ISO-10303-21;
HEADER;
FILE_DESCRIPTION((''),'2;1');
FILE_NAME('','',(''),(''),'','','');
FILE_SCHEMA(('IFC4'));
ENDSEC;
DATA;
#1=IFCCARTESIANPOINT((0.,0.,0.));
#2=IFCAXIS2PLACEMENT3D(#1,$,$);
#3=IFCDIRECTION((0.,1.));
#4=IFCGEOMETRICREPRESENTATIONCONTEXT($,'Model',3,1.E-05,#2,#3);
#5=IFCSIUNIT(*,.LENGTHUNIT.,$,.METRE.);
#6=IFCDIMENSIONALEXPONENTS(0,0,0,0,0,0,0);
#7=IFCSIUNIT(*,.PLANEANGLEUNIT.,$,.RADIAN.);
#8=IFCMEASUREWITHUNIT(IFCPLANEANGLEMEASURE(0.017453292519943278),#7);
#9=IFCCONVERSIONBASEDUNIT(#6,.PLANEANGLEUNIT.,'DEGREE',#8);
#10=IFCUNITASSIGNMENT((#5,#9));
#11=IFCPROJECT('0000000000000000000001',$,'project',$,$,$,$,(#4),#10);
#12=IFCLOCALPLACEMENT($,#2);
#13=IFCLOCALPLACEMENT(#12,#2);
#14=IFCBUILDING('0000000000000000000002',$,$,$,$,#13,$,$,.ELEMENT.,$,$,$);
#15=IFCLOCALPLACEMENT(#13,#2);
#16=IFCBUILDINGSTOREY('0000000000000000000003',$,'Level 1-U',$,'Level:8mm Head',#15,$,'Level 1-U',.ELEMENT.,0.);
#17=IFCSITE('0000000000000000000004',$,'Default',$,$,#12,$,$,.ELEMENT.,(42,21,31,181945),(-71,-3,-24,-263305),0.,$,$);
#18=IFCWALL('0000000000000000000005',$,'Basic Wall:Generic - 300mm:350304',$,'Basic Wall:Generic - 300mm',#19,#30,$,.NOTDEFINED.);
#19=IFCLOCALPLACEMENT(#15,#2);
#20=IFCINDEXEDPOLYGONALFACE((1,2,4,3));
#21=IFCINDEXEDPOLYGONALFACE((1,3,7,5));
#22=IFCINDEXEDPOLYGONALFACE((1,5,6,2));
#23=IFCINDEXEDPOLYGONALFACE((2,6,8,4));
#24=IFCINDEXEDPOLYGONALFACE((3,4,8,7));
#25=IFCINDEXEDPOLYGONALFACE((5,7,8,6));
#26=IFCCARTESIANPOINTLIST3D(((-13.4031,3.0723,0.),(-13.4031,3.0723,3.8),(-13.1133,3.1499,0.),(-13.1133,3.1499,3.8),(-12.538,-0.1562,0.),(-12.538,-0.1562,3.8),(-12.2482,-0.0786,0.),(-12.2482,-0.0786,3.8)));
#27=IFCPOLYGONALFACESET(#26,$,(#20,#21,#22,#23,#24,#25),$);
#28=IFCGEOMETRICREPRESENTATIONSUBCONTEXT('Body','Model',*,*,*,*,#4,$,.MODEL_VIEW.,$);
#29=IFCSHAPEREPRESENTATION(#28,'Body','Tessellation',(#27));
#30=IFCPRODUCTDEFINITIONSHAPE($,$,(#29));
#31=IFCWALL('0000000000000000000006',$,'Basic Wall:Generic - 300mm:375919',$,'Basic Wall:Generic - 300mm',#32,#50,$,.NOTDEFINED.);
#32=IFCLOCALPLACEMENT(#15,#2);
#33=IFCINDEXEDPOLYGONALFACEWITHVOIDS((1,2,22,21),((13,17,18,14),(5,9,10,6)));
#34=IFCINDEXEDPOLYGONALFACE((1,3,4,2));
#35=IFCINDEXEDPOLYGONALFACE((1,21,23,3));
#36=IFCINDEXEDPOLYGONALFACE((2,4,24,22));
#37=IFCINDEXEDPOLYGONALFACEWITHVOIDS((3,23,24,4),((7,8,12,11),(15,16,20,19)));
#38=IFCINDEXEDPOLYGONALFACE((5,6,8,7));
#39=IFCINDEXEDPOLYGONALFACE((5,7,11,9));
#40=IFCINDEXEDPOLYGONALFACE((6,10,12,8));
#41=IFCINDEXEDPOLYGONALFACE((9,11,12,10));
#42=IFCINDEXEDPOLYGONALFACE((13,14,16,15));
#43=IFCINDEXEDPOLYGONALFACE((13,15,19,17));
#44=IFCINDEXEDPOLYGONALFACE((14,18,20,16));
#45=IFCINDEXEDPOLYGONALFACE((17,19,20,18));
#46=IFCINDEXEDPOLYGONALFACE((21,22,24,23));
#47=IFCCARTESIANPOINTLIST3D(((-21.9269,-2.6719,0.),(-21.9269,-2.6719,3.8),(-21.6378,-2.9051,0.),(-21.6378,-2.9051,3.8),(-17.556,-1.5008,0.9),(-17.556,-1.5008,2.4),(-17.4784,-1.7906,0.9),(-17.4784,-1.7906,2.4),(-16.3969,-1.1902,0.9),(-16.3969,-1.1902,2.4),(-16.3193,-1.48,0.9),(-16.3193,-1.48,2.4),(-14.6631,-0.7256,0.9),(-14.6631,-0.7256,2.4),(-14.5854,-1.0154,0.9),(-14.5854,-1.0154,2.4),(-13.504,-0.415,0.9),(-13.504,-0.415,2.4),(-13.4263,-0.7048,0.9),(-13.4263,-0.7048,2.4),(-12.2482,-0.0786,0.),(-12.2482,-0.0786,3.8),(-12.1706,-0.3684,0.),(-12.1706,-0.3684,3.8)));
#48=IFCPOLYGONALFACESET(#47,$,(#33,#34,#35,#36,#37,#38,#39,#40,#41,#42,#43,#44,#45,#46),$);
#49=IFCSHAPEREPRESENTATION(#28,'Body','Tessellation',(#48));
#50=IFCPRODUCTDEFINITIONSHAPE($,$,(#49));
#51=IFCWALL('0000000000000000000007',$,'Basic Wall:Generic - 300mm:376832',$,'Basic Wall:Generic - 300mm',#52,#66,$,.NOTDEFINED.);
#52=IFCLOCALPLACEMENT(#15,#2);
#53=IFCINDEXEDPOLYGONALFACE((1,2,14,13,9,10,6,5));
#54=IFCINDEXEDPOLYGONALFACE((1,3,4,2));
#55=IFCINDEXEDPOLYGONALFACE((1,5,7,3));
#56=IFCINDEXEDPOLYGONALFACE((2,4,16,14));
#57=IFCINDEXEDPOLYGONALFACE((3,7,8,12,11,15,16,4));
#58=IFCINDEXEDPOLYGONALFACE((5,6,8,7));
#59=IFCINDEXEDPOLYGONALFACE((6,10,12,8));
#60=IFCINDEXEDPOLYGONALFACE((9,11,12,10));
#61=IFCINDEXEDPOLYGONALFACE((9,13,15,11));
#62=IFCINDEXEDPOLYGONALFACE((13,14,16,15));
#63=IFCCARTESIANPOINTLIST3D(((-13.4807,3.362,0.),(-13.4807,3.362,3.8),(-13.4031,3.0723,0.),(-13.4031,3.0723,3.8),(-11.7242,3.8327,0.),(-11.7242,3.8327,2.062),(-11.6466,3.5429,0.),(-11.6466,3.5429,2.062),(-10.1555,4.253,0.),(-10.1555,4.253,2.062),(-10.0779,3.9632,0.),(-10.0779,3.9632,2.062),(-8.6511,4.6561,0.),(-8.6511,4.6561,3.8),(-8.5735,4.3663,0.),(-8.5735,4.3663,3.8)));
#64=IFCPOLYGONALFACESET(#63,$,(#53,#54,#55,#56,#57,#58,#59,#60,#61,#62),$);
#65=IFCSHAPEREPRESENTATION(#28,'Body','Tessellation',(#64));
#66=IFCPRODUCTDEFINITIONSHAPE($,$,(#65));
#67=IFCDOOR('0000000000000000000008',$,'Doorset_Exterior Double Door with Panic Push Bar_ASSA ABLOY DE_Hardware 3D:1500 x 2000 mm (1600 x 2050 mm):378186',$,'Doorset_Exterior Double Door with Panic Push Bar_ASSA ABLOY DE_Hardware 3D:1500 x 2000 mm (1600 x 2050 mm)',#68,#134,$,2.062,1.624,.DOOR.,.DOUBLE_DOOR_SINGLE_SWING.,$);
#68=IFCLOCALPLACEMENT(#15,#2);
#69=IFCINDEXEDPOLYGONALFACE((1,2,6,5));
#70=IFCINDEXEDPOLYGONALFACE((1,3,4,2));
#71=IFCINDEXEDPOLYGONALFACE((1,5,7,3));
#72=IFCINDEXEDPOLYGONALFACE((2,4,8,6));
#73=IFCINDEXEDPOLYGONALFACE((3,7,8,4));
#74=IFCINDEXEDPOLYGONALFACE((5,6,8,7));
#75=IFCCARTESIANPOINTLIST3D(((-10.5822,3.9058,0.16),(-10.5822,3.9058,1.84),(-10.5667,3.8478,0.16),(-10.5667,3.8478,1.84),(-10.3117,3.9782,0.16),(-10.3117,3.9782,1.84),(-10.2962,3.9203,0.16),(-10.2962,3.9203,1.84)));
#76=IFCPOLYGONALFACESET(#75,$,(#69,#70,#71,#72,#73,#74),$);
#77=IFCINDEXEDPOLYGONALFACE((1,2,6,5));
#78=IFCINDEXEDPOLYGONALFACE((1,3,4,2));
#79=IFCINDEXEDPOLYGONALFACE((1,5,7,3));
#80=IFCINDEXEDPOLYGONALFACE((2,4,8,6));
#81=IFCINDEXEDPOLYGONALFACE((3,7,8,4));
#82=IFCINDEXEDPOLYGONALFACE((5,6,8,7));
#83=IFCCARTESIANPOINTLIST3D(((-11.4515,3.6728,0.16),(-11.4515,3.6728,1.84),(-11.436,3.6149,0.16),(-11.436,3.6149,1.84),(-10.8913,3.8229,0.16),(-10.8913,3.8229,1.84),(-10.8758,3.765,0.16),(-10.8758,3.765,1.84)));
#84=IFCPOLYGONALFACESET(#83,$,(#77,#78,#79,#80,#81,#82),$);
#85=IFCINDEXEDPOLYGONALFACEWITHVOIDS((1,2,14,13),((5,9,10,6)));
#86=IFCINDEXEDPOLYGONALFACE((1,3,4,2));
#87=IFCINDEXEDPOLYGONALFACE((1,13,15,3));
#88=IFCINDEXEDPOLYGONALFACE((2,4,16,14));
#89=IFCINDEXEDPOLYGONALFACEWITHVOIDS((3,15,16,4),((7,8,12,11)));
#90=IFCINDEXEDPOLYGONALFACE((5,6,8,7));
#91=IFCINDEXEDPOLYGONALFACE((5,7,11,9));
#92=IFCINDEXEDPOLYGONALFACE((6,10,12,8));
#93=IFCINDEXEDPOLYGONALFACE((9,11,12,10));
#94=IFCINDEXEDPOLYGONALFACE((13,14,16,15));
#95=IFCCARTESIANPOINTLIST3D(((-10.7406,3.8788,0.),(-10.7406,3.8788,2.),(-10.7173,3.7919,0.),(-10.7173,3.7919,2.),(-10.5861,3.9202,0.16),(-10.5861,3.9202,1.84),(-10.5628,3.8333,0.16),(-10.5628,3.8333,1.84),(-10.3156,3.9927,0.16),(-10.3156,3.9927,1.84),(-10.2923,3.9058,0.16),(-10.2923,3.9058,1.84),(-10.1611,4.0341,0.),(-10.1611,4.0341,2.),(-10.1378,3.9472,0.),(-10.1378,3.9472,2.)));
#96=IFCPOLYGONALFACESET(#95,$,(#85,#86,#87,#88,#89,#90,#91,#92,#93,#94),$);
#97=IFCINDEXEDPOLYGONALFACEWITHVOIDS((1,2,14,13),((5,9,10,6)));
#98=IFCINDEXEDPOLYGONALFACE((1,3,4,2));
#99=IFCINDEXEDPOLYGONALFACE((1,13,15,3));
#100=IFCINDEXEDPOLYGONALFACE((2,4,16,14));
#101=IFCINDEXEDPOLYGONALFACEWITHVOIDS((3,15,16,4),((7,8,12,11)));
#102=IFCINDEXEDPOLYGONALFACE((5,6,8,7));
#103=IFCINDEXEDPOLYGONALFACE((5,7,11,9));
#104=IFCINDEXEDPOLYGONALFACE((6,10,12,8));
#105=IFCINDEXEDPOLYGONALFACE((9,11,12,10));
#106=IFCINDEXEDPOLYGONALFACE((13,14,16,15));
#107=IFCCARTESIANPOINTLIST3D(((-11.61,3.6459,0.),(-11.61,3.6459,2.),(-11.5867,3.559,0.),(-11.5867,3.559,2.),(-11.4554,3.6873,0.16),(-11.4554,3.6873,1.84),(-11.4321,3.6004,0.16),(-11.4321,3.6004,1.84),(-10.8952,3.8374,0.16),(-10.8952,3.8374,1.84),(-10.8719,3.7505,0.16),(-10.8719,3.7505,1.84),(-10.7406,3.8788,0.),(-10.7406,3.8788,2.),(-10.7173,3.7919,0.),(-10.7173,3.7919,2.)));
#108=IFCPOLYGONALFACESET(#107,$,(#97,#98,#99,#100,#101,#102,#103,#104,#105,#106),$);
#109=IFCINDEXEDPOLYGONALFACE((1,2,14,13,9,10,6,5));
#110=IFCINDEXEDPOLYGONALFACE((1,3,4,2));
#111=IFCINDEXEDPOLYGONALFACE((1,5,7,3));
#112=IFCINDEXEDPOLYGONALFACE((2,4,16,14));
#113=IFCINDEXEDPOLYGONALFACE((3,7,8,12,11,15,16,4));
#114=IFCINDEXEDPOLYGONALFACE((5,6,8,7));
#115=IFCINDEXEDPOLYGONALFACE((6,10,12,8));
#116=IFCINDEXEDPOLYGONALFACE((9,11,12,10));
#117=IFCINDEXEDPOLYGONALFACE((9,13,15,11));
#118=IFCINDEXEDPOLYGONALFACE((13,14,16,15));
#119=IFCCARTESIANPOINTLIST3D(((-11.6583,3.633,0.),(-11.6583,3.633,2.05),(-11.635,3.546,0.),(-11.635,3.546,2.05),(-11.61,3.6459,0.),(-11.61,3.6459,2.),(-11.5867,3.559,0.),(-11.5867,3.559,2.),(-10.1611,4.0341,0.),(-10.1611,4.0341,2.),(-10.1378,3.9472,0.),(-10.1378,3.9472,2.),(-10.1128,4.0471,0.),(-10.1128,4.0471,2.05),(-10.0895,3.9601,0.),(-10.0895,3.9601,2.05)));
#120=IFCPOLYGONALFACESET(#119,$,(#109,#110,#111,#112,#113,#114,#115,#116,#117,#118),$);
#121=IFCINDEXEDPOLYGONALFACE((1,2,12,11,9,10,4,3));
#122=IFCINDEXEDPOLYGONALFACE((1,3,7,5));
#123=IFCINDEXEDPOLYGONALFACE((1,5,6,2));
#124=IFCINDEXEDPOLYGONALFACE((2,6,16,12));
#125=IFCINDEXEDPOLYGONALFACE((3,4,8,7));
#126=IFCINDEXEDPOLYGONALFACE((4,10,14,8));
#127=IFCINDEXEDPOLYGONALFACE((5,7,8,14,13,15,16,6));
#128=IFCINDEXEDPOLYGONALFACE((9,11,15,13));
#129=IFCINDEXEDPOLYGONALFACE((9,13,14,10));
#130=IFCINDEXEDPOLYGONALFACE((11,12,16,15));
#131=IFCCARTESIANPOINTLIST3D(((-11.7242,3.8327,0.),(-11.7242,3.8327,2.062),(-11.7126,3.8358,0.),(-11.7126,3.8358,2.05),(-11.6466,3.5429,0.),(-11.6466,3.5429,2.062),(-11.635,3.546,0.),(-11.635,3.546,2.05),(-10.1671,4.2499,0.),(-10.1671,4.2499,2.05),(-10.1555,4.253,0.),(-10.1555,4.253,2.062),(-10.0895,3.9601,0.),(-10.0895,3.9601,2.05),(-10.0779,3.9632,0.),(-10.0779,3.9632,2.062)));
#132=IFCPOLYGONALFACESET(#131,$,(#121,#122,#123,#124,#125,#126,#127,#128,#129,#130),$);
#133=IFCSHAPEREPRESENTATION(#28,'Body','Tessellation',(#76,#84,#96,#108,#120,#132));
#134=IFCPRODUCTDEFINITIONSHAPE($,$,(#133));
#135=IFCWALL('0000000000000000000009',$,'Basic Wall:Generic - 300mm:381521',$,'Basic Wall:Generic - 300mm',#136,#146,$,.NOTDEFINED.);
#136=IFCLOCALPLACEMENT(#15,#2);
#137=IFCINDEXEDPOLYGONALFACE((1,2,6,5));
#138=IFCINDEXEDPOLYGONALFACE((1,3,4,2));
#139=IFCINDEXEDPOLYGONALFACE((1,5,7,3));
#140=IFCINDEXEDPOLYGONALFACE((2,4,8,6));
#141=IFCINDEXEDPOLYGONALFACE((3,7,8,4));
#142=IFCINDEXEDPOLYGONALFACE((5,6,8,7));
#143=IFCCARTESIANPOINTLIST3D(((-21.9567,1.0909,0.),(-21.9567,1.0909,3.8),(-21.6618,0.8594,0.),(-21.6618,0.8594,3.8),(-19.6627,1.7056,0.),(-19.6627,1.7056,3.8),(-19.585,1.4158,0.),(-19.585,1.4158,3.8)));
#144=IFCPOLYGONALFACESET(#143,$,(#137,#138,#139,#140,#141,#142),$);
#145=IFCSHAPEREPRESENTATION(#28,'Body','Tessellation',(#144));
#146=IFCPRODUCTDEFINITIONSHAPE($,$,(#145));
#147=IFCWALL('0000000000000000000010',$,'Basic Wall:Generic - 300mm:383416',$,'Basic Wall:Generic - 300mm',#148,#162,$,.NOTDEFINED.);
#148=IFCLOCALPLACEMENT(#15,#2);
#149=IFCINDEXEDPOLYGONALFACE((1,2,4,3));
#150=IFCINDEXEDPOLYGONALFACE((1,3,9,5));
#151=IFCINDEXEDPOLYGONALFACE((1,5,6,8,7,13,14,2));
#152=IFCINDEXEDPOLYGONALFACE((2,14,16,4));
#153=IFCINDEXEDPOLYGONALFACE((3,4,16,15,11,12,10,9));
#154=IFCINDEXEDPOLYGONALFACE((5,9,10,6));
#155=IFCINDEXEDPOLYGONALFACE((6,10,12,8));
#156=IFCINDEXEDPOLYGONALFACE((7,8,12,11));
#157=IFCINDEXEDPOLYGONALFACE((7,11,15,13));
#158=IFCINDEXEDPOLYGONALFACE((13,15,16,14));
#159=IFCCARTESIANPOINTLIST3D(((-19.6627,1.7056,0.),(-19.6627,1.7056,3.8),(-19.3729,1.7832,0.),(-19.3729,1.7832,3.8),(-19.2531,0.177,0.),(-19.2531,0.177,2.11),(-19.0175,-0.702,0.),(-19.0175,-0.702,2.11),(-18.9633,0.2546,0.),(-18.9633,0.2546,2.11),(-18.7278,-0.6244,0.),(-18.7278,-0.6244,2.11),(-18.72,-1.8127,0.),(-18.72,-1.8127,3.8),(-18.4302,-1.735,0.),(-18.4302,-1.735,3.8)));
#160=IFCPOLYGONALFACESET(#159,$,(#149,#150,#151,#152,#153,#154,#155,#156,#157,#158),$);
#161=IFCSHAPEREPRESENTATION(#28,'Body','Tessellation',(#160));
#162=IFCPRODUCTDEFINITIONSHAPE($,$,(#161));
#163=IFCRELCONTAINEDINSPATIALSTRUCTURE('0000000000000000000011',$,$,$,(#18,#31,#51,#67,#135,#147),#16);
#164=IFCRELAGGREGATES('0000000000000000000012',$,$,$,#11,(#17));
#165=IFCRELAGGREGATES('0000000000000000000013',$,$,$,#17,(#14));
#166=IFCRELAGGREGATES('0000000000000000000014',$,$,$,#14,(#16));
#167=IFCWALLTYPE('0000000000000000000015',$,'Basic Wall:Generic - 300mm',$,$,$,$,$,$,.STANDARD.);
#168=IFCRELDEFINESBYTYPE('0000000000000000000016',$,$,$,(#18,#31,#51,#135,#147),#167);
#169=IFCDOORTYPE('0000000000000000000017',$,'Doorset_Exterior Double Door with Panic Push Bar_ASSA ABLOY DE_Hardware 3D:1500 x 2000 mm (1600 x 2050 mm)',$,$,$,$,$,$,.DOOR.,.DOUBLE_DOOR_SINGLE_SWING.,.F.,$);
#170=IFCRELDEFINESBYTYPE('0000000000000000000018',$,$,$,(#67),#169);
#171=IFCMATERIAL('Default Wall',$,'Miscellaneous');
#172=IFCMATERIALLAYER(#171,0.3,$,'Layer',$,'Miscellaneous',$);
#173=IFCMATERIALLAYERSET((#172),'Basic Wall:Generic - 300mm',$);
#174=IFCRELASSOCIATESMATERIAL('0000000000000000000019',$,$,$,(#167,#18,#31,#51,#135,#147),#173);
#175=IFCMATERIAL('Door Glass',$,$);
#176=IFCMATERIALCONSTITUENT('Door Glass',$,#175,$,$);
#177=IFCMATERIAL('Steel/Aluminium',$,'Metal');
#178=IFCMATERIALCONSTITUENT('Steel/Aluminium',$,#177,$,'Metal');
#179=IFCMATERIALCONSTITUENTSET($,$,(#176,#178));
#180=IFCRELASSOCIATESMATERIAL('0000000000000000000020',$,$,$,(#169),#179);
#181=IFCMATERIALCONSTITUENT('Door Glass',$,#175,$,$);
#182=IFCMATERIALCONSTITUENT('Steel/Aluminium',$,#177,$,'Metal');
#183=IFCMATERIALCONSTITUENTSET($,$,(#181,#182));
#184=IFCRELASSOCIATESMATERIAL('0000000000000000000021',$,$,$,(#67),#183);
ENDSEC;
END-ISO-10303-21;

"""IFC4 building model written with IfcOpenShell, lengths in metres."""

from ifc_helpers import new_model, entity, si_unit, converted_unit, direction, frame, frame_2d, origin, place, context, subcontext, project, spatial, polyline, rectangle, outline, extrude, source, transform, mapped, material, layer, layer_set, layer_usage, constituent, constituent_set, type_object, type_shapes, element, fill, save


model = new_model("IFC4")

# Units and contexts
model_context = context("Model", 3, precision=1e-05, world=origin(), true_north=direction((0.0, 1.0)))
body_context = subcontext(model_context, "Body", "Model", "MODEL_VIEW")
ifc_project = project(units=[si_unit("LENGTHUNIT", "METRE"), converted_unit("PLANEANGLEUNIT", "DEGREE", entity("IfcPlaneAngleMeasure", 0.017453292519943278), si_unit("PLANEANGLEUNIT", "RADIAN"), dimensions=[0, 0, 0, 0, 0, 0, 0])], contexts=[model_context])

# Site, building, storey
site_placement = place(None, origin())
site = spatial("IfcSite", under=ifc_project, at=site_placement, Name="Default", CompositionType="ELEMENT", RefLatitude=(42, 21, 31, 181945), RefLongitude=(-71, -3, -24, -263305), RefElevation=0.0)
building_placement = place(site_placement, origin())
building = spatial("IfcBuilding", under=site, at=building_placement, CompositionType="ELEMENT")
storey_placement = place(building_placement, origin())
storey = spatial("IfcBuildingStorey", under=building, at=storey_placement, Name="Level 1-U", ObjectType="Level:8mm Head", LongName="Level 1-U", CompositionType="ELEMENT", Elevation=0.0)

# Wall
ifc_material_1 = material(Name="Default Wall", Category="Miscellaneous")
ifc_layer_1 = layer(ifc_material_1, 0.3, Name="Layer", Category="Miscellaneous")
ifc_layer_set_1 = layer_set([ifc_layer_1], Name="Basic Wall:Generic - 300mm")
ifc_layer_usage_1 = layer_usage(ifc_layer_set_1, "AXIS2", "NEGATIVE", 0.15)
wall_type_1 = type_object("IfcWallType", Name="Basic Wall:Generic - 300mm", PredefinedType="STANDARD", material=ifc_layer_set_1)
wall_1_placement = place(storey_placement, frame((-13.2582, 3.1111, 0.0), z_axis=(0.0, 0.0, 1.0), x_axis=(0.258819, -0.965926, 0.0)))
element("IfcWall", 1, at=wall_1_placement, inside=storey, type_object=wall_type_1, material=ifc_layer_usage_1, Name="Basic Wall:Generic - 300mm:350304", ObjectType="Basic Wall:Generic - 300mm", PredefinedType="NOTDEFINED", context=body_context, shape_type="SweptSolid", body=[
    extrude(rectangle(XDim=3.3424, YDim=0.3, at=frame_2d((1.6712, 0.0), x_axis=(-1.0, 0.0))), origin(), (0.0, 0.0, 1.0), 3.8),
])

# Wall, openings
wall_2_placement = place(storey_placement, frame((-21.888, -2.8168, 0.0), z_axis=(0.0, 0.0, 1.0), x_axis=(0.965926, 0.258819, 0.0)))
wall_2 = element("IfcWall", 2, at=wall_2_placement, inside=storey, type_object=wall_type_1, material=ifc_layer_usage_1, Name="Basic Wall:Generic - 300mm:375919", ObjectType="Basic Wall:Generic - 300mm", PredefinedType="NOTDEFINED", context=body_context, shape_type="SweptSolid", body=[
    extrude(outline(polyline([(10.02, -0.15), (10.02, 0.15), (9.72, 0.15), (3.62, 0.15), (3.32, 0.15), (0.3713, 0.15), (0.0, 0.15), (0.2188, -0.15), (10.02, -0.15)])), origin(), (0.0, 0.0, 1.0), 3.8),
])
opening_1_placement = place(wall_2_placement, frame((5.725, 0.15, 0.9)))
element("IfcOpeningElement", 3, at=opening_1_placement, cuts=wall_2, PredefinedType="OPENING", context=body_context, shape_type="SweptSolid", body=[
    extrude(rectangle(XDim=1.5, YDim=1.2, at=frame_2d((0.75, 0.6), x_axis=(-1.0, 0.0))), frame((0.0, 0.0, 0.0), z_axis=(0.0, -1.0, 0.0), x_axis=(0.0, 0.0, 1.0)), (0.0, 0.0, 1.0), 0.3),
])
opening_2_placement = place(wall_2_placement, frame((8.72, 0.15, 0.9)))
element("IfcOpeningElement", 4, at=opening_2_placement, cuts=wall_2, PredefinedType="OPENING", context=body_context, shape_type="SweptSolid", body=[
    extrude(rectangle(XDim=1.5, YDim=1.2, at=frame_2d((0.75, 0.6), x_axis=(-1.0, 0.0))), frame((0.0, 0.0, 0.0), z_axis=(0.0, -1.0, 0.0), x_axis=(0.0, 0.0, 1.0)), (0.0, 0.0, 1.0), 0.3),
])

# Wall, opening, door
wall_3_placement = place(storey_placement, frame((-13.4419, 3.2171, 0.0), z_axis=(0.0, 0.0, 1.0), x_axis=(0.965926, 0.258819, 0.0)))
wall_3 = element("IfcWall", 5, at=wall_3_placement, inside=storey, type_object=wall_type_1, material=ifc_layer_usage_1, Name="Basic Wall:Generic - 300mm:376832", ObjectType="Basic Wall:Generic - 300mm", PredefinedType="NOTDEFINED", context=body_context, shape_type="SweptSolid", body=[
    extrude(rectangle(XDim=5.0, YDim=0.3, at=frame_2d((2.5, 0.0), x_axis=(1.0, 0.0))), origin(), (0.0, 0.0, 1.0), 3.8),
])
opening_3_placement = place(wall_3_placement, frame((3.4425, 0.15, 0.0)))
opening_3 = element("IfcOpeningElement", 6, at=opening_3_placement, cuts=wall_3, PredefinedType="OPENING", context=body_context, shape_type="SweptSolid", body=[
    extrude(rectangle(XDim=2.062, YDim=1.624, at=frame_2d((1.031, 0.812), x_axis=(-1.0, 0.0))), frame((0.0, 0.0, 0.0), z_axis=(0.0, -1.0, 0.0), x_axis=(0.0, 0.0, 1.0)), (0.0, 0.0, 1.0), 0.3),
])
ifc_material_2 = material(Name="Door Glass")
ifc_constituent_1 = constituent(ifc_material_2, Name="Door Glass")
ifc_material_3 = material(Name="Steel/Aluminium", Category="Metal")
ifc_constituent_2 = constituent(ifc_material_3, Name="Steel/Aluminium", Category="Metal")
ifc_constituent_set_1 = constituent_set(constituents=[ifc_constituent_1, ifc_constituent_2])
ifc_constituent_3 = constituent(ifc_material_2, Name="Door Glass")
ifc_constituent_4 = constituent(ifc_material_3, Name="Steel/Aluminium", Category="Metal")
ifc_constituent_set_2 = constituent_set(constituents=[ifc_constituent_3, ifc_constituent_4])
door_type = type_object("IfcDoorType", Name="Doorset_Exterior Double Door with Panic Push Bar_ASSA ABLOY DE_Hardware 3D:1500 x 2000 mm (1600 x 2050 mm)", OperationType="DOUBLE_DOOR_SINGLE_SWING", ParameterTakesPrecedence=False, PredefinedType="DOOR", material=ifc_constituent_set_2)
shared_shape_1 = source(origin(), body_context, "Body", "SweptSolid", [
    extrude(rectangle(XDim=0.06, YDim=0.28, at=frame_2d((0.0, 0.0), x_axis=(1.0, 0.0))), frame((0.362, 0.255, 0.16), z_axis=(0.0, 0.0, 1.0), x_axis=(0.0, 1.0, 0.0)), (0.0, 0.0, 1.0), 1.68),
    extrude(rectangle(XDim=0.06, YDim=0.58, at=frame_2d((0.0, 0.0), x_axis=(1.0, 0.0))), frame((1.112, 0.255, 0.16), z_axis=(0.0, 0.0, 1.0), x_axis=(0.0, 1.0, 0.0)), (0.0, 0.0, 1.0), 1.68),
    extrude(outline(polyline([(-0.3, -1.0), (0.3, -1.0), (0.3, 1.0), (-0.3, 1.0), (-0.3, -1.0)]), holes=[polyline([(0.14, -0.84), (-0.14, -0.84), (-0.14, 0.84), (0.14, 0.84), (0.14, -0.84)])]), frame((0.362, 0.21, 1.0), z_axis=(0.0, 1.0, 0.0), x_axis=(-1.0, 0.0, 0.0)), (0.0, 0.0, 1.0), 0.09),
    extrude(outline(polyline([(-1.0, -0.45), (1.0, -0.45), (1.0, 0.45), (-1.0, 0.45), (-1.0, -0.45)]), holes=[polyline([(-0.84, -0.29), (-0.84, 0.29), (0.84, 0.29), (0.84, -0.29), (-0.84, -0.29)])]), frame((1.112, 0.21, 1.0), z_axis=(0.0, 1.0, 0.0), x_axis=(0.0, 0.0, -1.0)), (0.0, 0.0, 1.0), 0.09),
    extrude(outline(polyline([(-1.0375, -0.8), (1.0125, -0.8), (1.0125, -0.75), (-0.9875, -0.75), (-0.9875, 0.75), (1.0125, 0.75), (1.0125, 0.8), (-1.0375, 0.8), (-1.0375, -0.8)])), frame((0.812, 0.21, 1.0125), z_axis=(0.0, 1.0, 0.0), x_axis=(0.0, 0.0, -1.0)), (0.0, 0.0, 1.0), 0.09),
    extrude(outline(polyline([(-0.812, -1.034), (0.812, -1.034), (0.812, 1.028), (0.8, 1.028), (0.8, -1.022), (-0.8, -1.022), (-0.8, 1.028), (-0.812, 1.028), (-0.812, -1.034)])), frame((0.812, 0.0, 1.028), z_axis=(0.0, 1.0, 0.0), x_axis=(1.0, 0.0, 0.0)), (0.0, 0.0, 1.0), 0.3),
])
type_shapes(door_type, [shared_shape_1])
door_placement = place(opening_3_placement, frame((0.0, 0.0, 0.0), z_axis=(0.0, 0.0, 1.0), x_axis=(-1.0, 0.0, 0.0)))
door = element("IfcDoor", 7, at=door_placement, inside=storey, type_object=door_type, material=ifc_constituent_set_1, Name="Doorset_Exterior Double Door with Panic Push Bar_ASSA ABLOY DE_Hardware 3D:1500 x 2000 mm (1600 x 2050 mm):378186", ObjectType="Doorset_Exterior Double Door with Panic Push Bar_ASSA ABLOY DE_Hardware 3D:1500 x 2000 mm (1600 x 2050 mm)", OperationType="DOUBLE_DOOR_SINGLE_SWING", OverallHeight=2.062, OverallWidth=1.624, PredefinedType="DOOR", context=body_context, shape_type="MappedRepresentation", body=[
    mapped(shared_shape_1, transform((0.0, 0.0, 0.0), scale=1.0)),
])
fill(opening_3, door)

# Wall
wall_4_placement = place(storey_placement, frame((-19.6238, 1.5607, 0.0), z_axis=(0.0, 0.0, 1.0), x_axis=(-0.965926, -0.258819, 0.0)))
element("IfcWall", 8, at=wall_4_placement, inside=storey, type_object=wall_type_1, material=ifc_layer_usage_1, Name="Basic Wall:Generic - 300mm:381521", ObjectType="Basic Wall:Generic - 300mm", PredefinedType="NOTDEFINED", context=body_context, shape_type="SweptSolid", body=[
    extrude(outline(polyline([(2.375, -0.15), (2.15, 0.15), (0.0, 0.15), (0.0, -0.15), (2.375, -0.15)])), origin(), (0.0, 0.0, 1.0), 3.8),
])

# Wall, opening
wall_5_placement = place(storey_placement, frame((-19.5178, 1.7444, 0.0), z_axis=(0.0, 0.0, 1.0), x_axis=(0.258819, -0.965926, 0.0)))
wall_5 = element("IfcWall", 9, at=wall_5_placement, inside=storey, type_object=wall_type_1, material=ifc_layer_usage_1, Name="Basic Wall:Generic - 300mm:383416", ObjectType="Basic Wall:Generic - 300mm", PredefinedType="NOTDEFINED", context=body_context, shape_type="SweptSolid", body=[
    extrude(rectangle(XDim=3.6424, YDim=0.3, at=frame_2d((1.8212, 0.0), x_axis=(-1.0, 0.0))), origin(), (0.0, 0.0, 1.0), 3.8),
])
opening_4_placement = place(wall_5_placement, frame((1.5826, -0.15, 0.0)))
element("IfcOpeningElement", 10, at=opening_4_placement, cuts=wall_5, PredefinedType="OPENING", context=body_context, shape_type="SweptSolid", body=[
    extrude(rectangle(XDim=2.11, YDim=0.91, at=frame_2d((1.055, 0.455), x_axis=(1.0, 0.0))), frame((0.0, 0.0, 0.0), z_axis=(0.0, 1.0, 0.0), x_axis=(0.0, 0.0, 1.0)), (0.0, 0.0, 1.0), 0.3),
])

save(model, "model.ifc")
